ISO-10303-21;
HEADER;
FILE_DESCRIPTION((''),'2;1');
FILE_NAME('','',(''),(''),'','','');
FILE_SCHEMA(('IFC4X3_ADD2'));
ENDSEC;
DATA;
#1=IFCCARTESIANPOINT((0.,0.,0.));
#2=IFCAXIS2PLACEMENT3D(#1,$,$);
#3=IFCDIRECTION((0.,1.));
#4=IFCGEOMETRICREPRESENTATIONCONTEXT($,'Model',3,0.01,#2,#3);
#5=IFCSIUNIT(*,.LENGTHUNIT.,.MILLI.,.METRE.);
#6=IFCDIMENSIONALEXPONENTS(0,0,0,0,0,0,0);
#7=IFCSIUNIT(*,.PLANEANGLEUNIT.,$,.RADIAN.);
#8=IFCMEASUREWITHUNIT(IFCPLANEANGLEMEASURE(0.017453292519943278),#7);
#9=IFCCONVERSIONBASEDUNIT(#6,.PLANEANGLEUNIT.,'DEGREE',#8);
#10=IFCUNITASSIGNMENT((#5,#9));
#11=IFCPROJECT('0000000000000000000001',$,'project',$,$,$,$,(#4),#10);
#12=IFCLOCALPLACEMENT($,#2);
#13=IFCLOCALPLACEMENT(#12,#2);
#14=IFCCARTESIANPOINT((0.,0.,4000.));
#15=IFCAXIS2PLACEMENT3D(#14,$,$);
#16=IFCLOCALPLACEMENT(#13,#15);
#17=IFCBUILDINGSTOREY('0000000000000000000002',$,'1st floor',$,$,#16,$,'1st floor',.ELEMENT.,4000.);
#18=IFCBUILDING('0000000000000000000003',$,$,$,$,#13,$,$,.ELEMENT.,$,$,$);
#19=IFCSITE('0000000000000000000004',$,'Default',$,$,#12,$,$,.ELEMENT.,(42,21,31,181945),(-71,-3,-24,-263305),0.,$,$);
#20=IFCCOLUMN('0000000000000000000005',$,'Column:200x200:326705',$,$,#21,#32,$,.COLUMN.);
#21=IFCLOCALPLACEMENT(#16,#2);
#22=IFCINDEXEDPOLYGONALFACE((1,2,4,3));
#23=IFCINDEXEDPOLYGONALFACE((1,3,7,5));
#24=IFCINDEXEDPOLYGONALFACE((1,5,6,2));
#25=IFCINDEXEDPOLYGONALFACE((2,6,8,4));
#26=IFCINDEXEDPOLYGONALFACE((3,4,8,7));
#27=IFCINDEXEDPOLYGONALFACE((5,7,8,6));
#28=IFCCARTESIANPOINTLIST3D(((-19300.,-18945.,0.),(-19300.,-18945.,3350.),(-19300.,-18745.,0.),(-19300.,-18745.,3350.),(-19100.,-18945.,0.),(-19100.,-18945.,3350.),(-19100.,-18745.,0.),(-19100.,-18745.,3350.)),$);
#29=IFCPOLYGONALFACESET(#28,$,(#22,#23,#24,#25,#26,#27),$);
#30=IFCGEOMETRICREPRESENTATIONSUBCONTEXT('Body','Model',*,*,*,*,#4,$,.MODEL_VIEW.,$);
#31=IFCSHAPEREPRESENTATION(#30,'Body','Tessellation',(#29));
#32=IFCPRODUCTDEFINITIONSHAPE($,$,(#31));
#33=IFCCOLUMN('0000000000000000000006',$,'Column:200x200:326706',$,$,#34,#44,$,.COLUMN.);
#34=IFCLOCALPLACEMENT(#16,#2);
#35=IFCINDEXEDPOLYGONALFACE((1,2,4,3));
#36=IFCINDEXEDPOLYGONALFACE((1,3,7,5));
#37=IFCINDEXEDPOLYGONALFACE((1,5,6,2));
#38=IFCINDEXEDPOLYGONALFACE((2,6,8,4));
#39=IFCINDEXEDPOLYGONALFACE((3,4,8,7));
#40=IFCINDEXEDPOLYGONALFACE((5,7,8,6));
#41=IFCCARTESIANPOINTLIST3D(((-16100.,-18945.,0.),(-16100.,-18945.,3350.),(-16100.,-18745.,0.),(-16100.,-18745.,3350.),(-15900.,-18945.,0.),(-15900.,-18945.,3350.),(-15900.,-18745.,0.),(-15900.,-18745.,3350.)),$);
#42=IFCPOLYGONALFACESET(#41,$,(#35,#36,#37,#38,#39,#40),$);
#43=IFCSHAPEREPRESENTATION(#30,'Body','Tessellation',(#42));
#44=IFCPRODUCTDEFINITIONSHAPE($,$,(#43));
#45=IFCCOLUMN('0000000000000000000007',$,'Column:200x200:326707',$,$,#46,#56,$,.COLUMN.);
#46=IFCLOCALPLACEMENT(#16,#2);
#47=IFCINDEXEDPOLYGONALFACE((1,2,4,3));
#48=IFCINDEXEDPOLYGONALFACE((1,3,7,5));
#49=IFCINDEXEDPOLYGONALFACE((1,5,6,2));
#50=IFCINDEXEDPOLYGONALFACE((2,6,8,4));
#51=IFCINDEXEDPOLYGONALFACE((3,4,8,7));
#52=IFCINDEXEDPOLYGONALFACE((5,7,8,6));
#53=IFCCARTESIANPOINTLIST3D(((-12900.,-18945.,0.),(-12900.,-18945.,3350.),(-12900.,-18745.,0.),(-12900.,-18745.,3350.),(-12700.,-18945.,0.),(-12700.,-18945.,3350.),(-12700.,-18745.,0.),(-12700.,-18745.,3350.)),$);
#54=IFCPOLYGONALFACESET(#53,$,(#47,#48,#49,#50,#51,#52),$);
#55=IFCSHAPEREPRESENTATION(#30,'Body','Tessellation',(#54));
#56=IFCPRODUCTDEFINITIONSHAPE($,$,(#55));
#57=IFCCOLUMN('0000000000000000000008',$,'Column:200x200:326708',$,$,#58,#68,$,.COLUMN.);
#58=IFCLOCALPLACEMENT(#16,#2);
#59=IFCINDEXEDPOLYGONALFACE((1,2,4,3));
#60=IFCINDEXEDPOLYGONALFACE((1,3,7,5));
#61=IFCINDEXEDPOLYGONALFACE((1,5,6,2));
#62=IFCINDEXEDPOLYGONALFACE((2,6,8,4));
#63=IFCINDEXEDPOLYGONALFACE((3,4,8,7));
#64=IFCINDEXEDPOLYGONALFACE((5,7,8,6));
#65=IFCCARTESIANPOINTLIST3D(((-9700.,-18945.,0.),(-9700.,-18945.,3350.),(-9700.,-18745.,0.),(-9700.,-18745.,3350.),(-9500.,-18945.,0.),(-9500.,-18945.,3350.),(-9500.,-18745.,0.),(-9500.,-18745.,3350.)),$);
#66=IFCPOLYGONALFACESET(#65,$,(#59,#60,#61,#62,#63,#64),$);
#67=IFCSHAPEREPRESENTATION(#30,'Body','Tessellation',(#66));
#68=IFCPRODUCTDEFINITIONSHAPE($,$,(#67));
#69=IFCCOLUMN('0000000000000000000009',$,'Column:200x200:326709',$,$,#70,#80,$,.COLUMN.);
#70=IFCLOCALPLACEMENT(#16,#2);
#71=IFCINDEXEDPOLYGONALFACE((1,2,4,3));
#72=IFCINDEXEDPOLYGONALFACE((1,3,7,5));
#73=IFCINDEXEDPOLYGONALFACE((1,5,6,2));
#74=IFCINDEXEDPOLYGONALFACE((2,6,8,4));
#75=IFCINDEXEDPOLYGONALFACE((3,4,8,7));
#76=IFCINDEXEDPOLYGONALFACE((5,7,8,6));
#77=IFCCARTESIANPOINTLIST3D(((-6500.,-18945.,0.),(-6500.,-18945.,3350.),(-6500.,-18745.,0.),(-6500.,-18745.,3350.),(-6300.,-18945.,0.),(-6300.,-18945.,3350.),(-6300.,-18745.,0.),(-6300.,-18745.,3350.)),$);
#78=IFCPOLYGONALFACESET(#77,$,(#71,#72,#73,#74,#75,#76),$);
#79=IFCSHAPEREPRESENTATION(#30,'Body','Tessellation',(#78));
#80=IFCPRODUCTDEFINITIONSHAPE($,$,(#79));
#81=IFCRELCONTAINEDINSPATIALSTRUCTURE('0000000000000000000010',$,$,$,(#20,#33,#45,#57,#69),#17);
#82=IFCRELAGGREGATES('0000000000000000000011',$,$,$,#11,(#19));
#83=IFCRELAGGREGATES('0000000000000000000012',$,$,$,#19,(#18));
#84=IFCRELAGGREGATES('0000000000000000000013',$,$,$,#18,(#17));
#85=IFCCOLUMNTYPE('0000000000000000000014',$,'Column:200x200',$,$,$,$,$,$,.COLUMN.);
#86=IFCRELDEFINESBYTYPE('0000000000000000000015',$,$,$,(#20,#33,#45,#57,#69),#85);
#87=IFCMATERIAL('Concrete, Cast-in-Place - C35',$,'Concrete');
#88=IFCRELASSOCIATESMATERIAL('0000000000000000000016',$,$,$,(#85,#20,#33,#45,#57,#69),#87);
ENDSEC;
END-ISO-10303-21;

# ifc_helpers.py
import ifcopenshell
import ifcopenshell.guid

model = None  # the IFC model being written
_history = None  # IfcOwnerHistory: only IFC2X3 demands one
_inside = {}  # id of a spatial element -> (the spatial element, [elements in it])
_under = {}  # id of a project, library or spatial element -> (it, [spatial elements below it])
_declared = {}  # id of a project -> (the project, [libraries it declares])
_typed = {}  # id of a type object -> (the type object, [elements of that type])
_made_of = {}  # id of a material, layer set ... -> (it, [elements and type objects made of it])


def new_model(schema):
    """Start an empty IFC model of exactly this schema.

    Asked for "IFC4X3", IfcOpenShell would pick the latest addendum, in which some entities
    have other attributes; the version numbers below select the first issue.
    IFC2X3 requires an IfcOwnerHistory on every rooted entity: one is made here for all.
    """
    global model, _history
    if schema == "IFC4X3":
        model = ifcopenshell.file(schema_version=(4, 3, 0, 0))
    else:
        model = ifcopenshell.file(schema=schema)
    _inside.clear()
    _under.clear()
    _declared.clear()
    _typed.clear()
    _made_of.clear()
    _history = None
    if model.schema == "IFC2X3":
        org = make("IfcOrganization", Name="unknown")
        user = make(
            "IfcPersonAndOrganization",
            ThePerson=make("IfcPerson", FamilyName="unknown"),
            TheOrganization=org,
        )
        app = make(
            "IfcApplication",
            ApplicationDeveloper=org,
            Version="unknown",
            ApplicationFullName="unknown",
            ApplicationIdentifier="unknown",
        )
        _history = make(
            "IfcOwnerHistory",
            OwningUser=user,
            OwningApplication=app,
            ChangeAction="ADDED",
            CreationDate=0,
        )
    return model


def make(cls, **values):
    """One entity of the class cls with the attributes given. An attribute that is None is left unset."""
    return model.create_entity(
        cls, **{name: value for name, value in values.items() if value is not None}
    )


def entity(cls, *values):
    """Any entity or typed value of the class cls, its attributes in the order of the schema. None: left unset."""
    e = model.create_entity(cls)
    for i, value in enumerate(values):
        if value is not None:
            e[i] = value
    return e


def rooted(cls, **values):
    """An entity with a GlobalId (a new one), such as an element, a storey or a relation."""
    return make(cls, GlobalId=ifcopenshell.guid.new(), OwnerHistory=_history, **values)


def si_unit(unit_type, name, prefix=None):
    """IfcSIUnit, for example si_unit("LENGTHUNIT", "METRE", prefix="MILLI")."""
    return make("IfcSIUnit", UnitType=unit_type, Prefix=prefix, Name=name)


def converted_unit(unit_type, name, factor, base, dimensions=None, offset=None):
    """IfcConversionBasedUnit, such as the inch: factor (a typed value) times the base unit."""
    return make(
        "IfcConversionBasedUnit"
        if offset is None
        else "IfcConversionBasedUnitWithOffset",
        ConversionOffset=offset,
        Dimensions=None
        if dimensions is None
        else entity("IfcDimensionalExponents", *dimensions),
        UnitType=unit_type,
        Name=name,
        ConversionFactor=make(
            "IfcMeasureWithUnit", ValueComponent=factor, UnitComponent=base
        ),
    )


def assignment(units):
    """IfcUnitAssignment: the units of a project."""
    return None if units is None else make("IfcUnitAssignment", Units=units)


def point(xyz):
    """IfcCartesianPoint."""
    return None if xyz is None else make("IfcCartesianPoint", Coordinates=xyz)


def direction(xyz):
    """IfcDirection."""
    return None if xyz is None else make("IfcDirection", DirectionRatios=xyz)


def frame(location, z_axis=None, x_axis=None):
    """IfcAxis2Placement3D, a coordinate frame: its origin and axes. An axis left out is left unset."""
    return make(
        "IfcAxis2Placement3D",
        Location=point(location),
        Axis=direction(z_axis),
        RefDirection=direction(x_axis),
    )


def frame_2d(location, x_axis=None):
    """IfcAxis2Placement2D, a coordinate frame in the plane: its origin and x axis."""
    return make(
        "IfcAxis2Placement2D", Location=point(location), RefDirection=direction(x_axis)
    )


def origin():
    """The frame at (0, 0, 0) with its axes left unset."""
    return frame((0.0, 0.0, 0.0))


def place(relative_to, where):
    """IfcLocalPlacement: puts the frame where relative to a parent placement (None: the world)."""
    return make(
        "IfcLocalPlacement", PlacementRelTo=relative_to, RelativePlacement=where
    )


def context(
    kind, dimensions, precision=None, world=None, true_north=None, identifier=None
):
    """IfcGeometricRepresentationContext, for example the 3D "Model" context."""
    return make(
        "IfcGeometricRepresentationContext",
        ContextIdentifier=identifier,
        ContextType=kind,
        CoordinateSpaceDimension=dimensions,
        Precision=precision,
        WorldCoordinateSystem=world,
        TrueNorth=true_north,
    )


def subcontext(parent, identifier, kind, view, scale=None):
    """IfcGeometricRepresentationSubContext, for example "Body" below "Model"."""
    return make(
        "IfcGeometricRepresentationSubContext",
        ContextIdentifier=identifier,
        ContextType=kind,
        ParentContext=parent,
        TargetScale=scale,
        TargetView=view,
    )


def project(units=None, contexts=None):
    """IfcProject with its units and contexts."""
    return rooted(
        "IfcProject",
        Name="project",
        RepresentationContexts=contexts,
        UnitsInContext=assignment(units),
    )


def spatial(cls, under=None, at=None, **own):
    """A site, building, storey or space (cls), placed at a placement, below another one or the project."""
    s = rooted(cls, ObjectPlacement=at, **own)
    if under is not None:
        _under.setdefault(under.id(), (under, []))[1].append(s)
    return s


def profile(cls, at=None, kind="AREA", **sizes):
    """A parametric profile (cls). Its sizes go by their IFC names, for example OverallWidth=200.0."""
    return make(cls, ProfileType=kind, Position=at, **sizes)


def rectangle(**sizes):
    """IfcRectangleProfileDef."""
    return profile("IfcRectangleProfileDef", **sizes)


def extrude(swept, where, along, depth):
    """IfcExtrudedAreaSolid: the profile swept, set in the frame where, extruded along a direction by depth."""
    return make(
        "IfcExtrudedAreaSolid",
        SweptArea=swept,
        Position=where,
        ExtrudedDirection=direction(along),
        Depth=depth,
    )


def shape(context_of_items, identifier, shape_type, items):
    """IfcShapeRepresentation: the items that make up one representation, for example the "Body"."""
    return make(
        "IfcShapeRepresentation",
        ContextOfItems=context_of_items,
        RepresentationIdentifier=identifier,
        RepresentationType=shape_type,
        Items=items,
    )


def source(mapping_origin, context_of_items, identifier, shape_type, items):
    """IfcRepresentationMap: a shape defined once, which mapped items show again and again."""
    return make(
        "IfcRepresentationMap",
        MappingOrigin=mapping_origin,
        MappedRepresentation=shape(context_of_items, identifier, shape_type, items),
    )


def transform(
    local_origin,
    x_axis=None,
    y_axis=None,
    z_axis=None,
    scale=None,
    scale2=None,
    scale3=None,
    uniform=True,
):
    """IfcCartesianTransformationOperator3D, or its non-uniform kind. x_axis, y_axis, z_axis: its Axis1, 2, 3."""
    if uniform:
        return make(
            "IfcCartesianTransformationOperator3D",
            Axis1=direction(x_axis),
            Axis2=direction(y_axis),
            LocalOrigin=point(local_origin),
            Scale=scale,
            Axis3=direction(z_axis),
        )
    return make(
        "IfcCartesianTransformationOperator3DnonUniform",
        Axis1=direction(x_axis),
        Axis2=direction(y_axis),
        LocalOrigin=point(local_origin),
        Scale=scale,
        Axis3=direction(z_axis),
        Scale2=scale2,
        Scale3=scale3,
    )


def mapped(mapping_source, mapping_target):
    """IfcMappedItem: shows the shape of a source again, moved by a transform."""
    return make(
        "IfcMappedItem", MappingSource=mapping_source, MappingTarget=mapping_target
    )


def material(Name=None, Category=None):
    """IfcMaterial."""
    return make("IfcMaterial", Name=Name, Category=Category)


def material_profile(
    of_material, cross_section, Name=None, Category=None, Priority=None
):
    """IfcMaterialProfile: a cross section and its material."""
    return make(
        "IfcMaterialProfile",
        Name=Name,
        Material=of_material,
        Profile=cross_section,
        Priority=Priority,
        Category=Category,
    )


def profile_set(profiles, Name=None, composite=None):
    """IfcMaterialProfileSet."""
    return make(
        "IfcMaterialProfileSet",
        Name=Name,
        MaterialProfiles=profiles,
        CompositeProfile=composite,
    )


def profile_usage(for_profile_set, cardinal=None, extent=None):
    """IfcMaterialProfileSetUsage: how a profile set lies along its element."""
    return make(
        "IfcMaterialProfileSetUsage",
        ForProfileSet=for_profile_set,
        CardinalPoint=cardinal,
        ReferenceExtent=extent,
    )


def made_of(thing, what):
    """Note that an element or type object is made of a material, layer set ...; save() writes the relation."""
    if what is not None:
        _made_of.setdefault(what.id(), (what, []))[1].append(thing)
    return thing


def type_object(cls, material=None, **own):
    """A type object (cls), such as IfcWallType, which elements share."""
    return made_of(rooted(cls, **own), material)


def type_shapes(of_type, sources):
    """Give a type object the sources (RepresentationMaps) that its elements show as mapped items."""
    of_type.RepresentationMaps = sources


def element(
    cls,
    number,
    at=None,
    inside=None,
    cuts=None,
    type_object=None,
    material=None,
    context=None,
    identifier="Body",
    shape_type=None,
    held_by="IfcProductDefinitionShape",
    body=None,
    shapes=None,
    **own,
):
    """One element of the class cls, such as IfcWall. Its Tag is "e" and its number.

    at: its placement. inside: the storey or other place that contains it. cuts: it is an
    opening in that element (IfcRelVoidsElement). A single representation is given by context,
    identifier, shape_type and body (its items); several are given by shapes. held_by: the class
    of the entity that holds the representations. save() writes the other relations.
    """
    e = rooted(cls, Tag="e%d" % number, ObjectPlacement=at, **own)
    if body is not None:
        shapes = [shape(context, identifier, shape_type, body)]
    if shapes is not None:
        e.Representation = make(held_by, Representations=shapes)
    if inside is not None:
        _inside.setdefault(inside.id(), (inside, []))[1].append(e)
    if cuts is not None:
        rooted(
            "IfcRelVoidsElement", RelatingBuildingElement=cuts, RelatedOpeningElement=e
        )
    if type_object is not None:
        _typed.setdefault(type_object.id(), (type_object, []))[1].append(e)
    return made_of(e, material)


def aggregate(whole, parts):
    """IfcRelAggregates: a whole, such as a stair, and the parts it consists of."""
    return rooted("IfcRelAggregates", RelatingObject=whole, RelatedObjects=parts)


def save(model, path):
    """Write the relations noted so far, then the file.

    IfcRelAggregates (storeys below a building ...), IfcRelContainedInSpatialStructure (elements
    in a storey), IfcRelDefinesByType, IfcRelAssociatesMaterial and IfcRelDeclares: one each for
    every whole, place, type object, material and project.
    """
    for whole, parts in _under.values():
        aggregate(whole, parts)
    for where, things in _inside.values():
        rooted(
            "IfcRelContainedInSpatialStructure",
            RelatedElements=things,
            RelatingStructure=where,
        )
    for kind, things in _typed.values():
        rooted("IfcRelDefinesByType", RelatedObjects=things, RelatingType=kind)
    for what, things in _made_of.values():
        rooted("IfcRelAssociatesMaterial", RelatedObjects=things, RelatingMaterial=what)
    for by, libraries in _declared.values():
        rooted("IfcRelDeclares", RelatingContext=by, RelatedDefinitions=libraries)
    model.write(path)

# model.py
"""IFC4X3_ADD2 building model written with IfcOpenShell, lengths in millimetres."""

from ifc_helpers import new_model, entity, si_unit, converted_unit, direction, frame, frame_2d, origin, place, context, subcontext, project, spatial, rectangle, extrude, source, transform, mapped, material, material_profile, profile_set, profile_usage, type_object, type_shapes, element, save


model = new_model("IFC4X3_ADD2")

# Units and contexts
model_context = context("Model", 3, precision=0.01, world=origin(), true_north=direction((0.0, 1.0)))
body_context = subcontext(model_context, "Body", "Model", "MODEL_VIEW")
ifc_project = project(units=[si_unit("LENGTHUNIT", "METRE", prefix="MILLI"), converted_unit("PLANEANGLEUNIT", "DEGREE", entity("IfcPlaneAngleMeasure", 0.017453292519943278), si_unit("PLANEANGLEUNIT", "RADIAN"), dimensions=[0, 0, 0, 0, 0, 0, 0])], contexts=[model_context])

# Site, building, storey
site_placement = place(None, origin())
site = spatial("IfcSite", under=ifc_project, at=site_placement, Name="Default", CompositionType="ELEMENT", RefLatitude=(42, 21, 31, 181945), RefLongitude=(-71, -3, -24, -263305), RefElevation=0.0)
building_placement = place(site_placement, origin())
building = spatial("IfcBuilding", under=site, at=building_placement, CompositionType="ELEMENT")
storey_placement = place(building_placement, frame((0.0, 0.0, 4000.0)))
storey = spatial("IfcBuildingStorey", under=building, at=storey_placement, Name="1st floor", LongName="1st floor", CompositionType="ELEMENT", Elevation=4000.0)

# Columns
ifc_material = material(Name="Concrete, Cast-in-Place - C35", Category="Concrete")
ifc_material_profile_1 = material_profile(ifc_material, rectangle(XDim=200.0, YDim=200.0, at=frame_2d((0.0, 0.0), x_axis=(1.0, 0.0))), Name="200x200")
ifc_profile_set_1 = profile_set([ifc_material_profile_1], Name="200x200")
ifc_profile_usage_1 = profile_usage(ifc_profile_set_1)
column_type_1 = type_object("IfcColumnType", Name="Column:200x200", PredefinedType="COLUMN", material=ifc_profile_set_1)
shared_shape_1 = source(origin(), body_context, "Body", "SweptSolid", [
    extrude(rectangle(XDim=200.0, YDim=200.0, at=frame_2d((0.0, 0.0), x_axis=(1.0, 0.0))), frame((0.0, 0.0, 4000.0), z_axis=(0.0, 0.0, 1.0), x_axis=(-1.0, 0.0, 0.0)), (0.0, 0.0, 1.0), 3350.0),
])
type_shapes(column_type_1, [shared_shape_1])
for number, where, name in (
    (1, (-19200.0, -18845.0, -4000.0), "Column:200x200:326705"),
    (2, (-16000.0, -18845.0, -4000.0), "Column:200x200:326706"),
    (3, (-12800.0, -18845.0, -4000.0), "Column:200x200:326707"),
    (4, (-9600.0, -18845.0, -4000.0), "Column:200x200:326708"),
    (5, (-6400.0, -18845.0, -4000.0), "Column:200x200:326709"),
):
    element("IfcColumn", number, at=place(storey_placement, frame(where)), inside=storey, type_object=column_type_1, material=ifc_profile_usage_1, Name=name, PredefinedType="COLUMN", context=body_context, shape_type="MappedRepresentation", body=[
        mapped(shared_shape_1, transform((0.0, 0.0, 0.0), scale=1.0)),
    ])

save(model, "model.ifc")
